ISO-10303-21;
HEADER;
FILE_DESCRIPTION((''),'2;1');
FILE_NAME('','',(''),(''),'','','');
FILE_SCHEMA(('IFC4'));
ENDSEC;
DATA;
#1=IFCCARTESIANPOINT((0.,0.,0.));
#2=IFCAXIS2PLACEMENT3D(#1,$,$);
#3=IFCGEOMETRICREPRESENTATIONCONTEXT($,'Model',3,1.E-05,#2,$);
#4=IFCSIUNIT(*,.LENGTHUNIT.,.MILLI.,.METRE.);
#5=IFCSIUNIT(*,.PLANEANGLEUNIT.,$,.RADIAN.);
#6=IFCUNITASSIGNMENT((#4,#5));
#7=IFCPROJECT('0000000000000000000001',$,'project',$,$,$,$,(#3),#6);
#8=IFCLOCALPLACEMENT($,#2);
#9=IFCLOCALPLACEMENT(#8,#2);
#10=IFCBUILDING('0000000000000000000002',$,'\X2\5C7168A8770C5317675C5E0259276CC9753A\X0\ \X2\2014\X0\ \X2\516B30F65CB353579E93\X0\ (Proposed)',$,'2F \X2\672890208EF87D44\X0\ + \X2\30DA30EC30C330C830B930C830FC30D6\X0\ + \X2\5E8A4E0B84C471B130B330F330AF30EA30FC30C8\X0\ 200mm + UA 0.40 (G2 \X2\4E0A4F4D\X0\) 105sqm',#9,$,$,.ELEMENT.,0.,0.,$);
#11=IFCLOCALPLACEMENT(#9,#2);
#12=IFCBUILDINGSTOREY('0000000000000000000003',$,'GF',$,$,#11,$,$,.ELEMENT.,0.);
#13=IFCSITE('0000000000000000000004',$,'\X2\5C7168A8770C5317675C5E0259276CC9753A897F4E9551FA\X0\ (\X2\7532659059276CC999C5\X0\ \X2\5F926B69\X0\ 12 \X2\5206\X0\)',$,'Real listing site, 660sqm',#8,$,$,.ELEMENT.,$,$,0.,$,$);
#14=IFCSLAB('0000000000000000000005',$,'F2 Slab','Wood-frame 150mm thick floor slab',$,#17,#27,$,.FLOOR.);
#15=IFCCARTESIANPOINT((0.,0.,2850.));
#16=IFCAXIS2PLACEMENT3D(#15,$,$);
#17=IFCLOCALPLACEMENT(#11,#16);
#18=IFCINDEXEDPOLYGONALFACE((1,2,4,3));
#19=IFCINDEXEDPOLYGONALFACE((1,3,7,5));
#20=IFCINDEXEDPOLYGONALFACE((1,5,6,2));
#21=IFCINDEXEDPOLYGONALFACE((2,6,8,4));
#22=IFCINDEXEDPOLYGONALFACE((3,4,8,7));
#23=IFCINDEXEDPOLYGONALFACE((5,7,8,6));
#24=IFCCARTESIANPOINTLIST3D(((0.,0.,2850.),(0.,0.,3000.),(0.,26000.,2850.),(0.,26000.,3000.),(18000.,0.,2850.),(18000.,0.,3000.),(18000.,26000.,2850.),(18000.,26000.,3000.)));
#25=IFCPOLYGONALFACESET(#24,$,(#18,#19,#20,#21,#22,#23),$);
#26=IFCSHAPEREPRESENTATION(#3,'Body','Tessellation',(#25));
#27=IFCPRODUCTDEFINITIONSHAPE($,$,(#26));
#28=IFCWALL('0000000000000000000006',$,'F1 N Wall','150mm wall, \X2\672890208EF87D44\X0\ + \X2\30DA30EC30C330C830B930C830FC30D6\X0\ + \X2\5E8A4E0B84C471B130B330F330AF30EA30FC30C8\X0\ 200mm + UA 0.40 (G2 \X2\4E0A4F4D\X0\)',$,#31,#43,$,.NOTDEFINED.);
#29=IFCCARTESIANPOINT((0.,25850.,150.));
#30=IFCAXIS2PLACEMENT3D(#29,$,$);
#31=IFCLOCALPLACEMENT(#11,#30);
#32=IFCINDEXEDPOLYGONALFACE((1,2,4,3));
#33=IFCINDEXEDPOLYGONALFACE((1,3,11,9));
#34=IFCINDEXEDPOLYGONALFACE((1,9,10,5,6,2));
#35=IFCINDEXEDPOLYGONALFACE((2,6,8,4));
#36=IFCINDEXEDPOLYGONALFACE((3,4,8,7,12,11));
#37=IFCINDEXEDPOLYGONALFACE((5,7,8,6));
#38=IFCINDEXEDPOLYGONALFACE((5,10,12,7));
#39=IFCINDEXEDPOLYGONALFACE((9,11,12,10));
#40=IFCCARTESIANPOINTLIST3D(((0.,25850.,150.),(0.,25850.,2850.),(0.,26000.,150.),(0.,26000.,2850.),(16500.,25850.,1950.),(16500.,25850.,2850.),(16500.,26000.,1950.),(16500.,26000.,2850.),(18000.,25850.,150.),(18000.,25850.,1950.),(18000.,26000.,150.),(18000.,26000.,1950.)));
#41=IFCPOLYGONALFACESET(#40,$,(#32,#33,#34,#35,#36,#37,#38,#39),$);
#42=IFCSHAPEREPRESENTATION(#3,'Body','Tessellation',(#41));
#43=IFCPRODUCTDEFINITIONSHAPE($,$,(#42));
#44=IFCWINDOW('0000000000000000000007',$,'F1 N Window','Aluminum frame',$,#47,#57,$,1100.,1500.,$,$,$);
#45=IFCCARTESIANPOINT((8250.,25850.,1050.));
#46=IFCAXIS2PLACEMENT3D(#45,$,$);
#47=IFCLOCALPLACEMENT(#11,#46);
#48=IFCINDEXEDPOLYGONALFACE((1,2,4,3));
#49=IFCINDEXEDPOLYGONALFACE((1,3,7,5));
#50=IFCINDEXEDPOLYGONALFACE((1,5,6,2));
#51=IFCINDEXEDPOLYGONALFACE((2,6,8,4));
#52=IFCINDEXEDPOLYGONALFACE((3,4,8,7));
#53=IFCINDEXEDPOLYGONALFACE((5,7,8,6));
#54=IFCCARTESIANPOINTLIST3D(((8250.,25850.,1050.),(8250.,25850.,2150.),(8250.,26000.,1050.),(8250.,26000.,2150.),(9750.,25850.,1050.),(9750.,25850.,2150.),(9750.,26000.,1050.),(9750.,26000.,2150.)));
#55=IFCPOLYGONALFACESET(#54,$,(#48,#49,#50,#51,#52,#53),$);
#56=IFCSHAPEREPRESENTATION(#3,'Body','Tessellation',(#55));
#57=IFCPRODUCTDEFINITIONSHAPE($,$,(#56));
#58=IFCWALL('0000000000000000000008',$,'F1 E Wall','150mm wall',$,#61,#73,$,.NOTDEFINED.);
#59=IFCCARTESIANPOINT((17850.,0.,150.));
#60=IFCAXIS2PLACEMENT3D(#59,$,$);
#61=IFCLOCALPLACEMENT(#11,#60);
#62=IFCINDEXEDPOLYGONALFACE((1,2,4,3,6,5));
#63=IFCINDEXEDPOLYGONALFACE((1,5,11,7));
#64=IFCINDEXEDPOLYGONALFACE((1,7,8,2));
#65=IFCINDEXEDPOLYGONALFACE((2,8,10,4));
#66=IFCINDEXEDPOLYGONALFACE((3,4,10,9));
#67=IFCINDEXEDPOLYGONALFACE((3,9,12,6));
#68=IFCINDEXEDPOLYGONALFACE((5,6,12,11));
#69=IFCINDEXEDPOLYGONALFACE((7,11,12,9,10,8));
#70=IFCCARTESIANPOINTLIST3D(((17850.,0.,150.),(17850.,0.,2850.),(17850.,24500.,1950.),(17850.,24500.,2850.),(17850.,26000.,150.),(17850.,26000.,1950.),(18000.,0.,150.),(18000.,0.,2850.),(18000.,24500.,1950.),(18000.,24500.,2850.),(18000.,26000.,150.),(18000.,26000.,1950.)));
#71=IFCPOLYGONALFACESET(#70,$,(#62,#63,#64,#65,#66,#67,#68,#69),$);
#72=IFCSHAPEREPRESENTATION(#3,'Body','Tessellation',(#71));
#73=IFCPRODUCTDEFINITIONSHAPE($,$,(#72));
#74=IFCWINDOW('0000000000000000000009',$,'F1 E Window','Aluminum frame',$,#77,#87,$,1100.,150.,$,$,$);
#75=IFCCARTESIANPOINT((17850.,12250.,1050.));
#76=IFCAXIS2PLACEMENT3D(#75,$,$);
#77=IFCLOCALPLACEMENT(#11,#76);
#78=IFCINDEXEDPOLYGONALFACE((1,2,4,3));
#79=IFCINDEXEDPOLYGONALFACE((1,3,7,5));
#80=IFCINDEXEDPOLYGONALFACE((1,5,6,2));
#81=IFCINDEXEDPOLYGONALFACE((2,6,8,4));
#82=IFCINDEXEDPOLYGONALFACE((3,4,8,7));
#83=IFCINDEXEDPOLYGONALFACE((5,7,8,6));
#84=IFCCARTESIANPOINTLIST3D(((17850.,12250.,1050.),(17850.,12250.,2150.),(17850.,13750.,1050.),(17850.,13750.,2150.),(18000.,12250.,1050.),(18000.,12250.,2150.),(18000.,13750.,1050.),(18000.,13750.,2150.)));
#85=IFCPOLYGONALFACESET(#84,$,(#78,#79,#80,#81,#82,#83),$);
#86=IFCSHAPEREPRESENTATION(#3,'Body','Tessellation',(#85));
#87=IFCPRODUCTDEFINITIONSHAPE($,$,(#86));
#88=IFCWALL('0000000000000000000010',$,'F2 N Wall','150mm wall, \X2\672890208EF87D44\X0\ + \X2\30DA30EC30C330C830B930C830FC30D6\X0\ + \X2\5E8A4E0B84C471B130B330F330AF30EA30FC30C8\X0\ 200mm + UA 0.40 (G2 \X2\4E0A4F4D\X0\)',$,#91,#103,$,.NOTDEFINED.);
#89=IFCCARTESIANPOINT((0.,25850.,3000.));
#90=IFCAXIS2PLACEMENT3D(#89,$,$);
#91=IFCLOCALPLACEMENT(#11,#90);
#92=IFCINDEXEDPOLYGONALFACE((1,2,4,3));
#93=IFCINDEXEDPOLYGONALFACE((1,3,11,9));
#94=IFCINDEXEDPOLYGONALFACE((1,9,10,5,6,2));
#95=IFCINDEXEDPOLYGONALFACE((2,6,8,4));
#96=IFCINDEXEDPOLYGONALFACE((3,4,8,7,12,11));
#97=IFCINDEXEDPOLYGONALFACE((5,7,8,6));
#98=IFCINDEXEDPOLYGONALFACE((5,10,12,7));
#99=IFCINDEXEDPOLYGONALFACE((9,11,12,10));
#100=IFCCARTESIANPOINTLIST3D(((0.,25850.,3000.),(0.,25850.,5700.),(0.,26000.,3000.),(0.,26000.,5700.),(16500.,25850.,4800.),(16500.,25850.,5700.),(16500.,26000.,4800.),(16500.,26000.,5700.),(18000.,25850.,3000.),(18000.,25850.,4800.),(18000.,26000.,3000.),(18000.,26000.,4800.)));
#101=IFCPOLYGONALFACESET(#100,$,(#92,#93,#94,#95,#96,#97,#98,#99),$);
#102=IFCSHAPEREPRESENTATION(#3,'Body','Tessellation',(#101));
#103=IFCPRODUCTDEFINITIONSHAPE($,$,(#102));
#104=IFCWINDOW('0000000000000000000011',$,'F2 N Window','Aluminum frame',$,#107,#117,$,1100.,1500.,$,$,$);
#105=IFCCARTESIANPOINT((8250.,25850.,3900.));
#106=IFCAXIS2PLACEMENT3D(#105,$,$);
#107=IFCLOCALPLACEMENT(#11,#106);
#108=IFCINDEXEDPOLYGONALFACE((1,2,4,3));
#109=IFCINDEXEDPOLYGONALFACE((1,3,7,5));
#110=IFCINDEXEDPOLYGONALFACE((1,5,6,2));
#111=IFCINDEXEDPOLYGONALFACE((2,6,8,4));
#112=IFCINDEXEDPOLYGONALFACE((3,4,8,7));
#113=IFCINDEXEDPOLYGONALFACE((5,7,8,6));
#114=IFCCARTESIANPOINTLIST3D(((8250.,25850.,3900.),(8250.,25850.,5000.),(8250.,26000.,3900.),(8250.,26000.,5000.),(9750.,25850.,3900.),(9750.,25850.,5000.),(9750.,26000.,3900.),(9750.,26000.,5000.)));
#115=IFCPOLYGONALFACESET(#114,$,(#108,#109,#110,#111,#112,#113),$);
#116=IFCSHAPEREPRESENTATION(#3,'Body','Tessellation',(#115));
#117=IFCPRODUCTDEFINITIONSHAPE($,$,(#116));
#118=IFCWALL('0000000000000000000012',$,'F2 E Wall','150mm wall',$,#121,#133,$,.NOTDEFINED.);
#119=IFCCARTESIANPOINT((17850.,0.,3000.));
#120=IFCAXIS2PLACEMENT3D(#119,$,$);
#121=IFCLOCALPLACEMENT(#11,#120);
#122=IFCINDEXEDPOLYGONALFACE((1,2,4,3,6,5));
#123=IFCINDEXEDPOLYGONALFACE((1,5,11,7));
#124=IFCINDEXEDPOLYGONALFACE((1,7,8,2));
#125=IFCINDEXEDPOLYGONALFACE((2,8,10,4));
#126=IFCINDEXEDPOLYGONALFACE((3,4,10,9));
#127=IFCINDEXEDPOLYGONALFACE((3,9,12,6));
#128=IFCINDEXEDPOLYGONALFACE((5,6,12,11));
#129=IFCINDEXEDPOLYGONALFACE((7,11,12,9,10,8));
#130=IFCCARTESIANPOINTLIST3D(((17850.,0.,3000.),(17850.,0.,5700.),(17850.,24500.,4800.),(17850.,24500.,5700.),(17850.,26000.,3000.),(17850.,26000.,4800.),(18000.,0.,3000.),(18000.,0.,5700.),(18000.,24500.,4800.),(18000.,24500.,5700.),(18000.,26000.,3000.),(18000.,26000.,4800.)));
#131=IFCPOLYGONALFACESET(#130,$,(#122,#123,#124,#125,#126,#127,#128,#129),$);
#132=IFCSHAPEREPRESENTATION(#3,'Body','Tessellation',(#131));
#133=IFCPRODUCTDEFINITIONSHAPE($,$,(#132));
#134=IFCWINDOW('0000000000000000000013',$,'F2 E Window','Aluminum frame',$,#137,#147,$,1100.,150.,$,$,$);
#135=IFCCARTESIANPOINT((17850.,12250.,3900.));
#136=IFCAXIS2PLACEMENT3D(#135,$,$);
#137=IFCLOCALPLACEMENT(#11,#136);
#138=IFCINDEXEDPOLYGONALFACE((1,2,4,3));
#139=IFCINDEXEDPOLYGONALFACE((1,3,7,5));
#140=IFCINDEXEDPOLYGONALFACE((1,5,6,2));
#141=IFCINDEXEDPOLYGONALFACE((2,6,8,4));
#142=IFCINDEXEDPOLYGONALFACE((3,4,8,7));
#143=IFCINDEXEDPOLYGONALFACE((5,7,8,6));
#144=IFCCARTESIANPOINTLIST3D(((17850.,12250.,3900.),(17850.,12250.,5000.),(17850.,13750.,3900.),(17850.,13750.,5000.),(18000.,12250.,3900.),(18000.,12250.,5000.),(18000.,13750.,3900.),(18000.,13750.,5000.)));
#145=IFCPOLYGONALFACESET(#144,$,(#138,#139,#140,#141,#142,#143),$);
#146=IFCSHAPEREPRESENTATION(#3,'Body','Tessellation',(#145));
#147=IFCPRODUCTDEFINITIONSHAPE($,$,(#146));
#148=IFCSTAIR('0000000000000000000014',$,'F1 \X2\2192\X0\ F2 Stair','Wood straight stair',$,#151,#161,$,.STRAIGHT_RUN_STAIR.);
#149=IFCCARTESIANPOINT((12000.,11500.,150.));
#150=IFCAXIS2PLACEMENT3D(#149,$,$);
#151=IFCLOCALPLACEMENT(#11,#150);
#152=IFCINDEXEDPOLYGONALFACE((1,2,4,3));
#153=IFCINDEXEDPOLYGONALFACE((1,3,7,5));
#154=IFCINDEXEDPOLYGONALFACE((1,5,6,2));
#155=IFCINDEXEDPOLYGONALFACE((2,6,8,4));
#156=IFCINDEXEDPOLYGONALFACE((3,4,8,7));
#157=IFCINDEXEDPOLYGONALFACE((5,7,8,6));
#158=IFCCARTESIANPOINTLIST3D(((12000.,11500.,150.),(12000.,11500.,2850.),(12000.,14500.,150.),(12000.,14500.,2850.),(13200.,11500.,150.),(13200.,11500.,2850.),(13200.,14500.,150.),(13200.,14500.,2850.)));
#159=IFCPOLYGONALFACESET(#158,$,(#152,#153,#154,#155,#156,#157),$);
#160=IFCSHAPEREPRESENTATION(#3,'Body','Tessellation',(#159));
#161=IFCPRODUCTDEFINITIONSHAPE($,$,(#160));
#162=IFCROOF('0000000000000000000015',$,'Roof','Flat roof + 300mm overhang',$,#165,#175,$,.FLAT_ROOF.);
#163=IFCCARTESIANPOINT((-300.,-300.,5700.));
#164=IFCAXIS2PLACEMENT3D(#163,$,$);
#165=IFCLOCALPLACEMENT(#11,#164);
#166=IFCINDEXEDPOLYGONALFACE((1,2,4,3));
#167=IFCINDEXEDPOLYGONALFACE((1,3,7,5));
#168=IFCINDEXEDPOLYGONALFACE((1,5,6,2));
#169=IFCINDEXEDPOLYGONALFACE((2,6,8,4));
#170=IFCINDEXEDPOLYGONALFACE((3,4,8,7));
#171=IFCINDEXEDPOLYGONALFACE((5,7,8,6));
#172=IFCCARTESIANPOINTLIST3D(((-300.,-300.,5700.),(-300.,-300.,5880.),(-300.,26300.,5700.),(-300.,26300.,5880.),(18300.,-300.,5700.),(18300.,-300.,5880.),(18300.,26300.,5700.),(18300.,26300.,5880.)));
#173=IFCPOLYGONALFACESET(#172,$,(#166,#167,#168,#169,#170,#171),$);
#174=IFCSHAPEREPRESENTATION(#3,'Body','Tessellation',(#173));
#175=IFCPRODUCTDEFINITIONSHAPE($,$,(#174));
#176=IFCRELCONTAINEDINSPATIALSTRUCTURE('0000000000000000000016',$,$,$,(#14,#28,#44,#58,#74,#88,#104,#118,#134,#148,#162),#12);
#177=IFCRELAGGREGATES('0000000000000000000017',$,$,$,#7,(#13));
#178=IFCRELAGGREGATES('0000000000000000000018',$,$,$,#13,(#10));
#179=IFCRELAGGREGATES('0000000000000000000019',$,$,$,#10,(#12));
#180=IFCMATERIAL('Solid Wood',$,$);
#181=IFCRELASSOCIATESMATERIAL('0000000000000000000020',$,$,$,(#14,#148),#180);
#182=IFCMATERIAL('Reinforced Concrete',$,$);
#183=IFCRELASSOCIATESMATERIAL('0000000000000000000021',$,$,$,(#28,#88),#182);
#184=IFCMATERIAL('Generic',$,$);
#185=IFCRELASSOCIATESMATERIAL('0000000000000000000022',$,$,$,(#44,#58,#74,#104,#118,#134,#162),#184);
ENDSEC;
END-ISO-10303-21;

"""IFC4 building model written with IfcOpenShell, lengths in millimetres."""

from ifc_helpers import new_model, si_unit, frame, frame_2d, origin, place, context, project, spatial, rectangle, extrude, material, element, fill, save


model = new_model("IFC4")

# Units and contexts
model_context = context("Model", 3, precision=1e-05, world=origin())
ifc_project = project(units=[si_unit("LENGTHUNIT", "METRE", prefix="MILLI"), si_unit("PLANEANGLEUNIT", "RADIAN")], contexts=[model_context])

# Site, building, storey
site_placement = place(None, origin())
site = spatial("IfcSite", under=ifc_project, at=site_placement, Name="山梨県北杜市大泉町西井出 (甲斐大泉駅 徒歩 12 分)", ObjectType="Real listing site, 660sqm", CompositionType="ELEMENT", RefElevation=0.0)
building_placement = place(site_placement, origin())
building = spatial("IfcBuilding", under=site, at=building_placement, Name="山梨県北杜市大泉町 — 八ヶ岳南麓 (Proposed)", ObjectType="2F 木造軸組 + ペレットストーブ + 床下蓄熱コンクリート 200mm + UA 0.40 (G2 上位) 105sqm", CompositionType="ELEMENT", ElevationOfRefHeight=0.0, ElevationOfTerrain=0.0)
storey_placement = place(building_placement, origin())
storey = spatial("IfcBuildingStorey", under=building, at=storey_placement, Name="GF", CompositionType="ELEMENT", Elevation=0.0)

# Slab
ifc_material_1 = material(Name="Solid Wood")
slab_1_placement = place(storey_placement, frame((0.0, 0.0, 2850.0)))
element("IfcSlab", 1, at=slab_1_placement, inside=storey, material=ifc_material_1, Name="F2 Slab", Description="Wood-frame 150mm thick floor slab", PredefinedType="FLOOR", context=model_context, shape_type="SweptSolid", body=[
    extrude(rectangle(XDim=18000.0, YDim=26000.0, at=frame_2d((9000.0, 13000.0))), frame((0.0, 0.0, 2850.0)), (0.0, 0.0, 1.0), 150.0),
])

# Wall, opening, window
ifc_material_2 = material(Name="Reinforced Concrete")
wall_1_placement = place(storey_placement, frame((0.0, 25850.0, 150.0)))
wall_1 = element("IfcWall", 2, at=wall_1_placement, inside=storey, material=ifc_material_2, Name="F1 N Wall", Description="150mm wall, 木造軸組 + ペレットストーブ + 床下蓄熱コンクリート 200mm + UA 0.40 (G2 上位)", PredefinedType="NOTDEFINED", context=model_context, shape_type="SweptSolid", body=[
    extrude(rectangle(XDim=18000.0, YDim=150.0, at=frame_2d((9000.0, 75.0))), frame((0.0, 25850.0, 150.0)), (0.0, 0.0, 1.0), 2700.0),
])
opening_1_placement = place(storey_placement, frame((8250.0, 25850.0, 1050.0)))
opening_1 = element("IfcOpeningElement", 3, at=opening_1_placement, cuts=wall_1, PredefinedType="NOTDEFINED", context=model_context, shape_type="SweptSolid", body=[
    extrude(rectangle(XDim=1500.0, YDim=150.0, at=frame_2d((750.0, 75.0))), frame((8250.0, 25850.0, 1050.0)), (0.0, 0.0, 1.0), 1100.0),
])
ifc_material_3 = material(Name="Generic")
window_1_placement = place(storey_placement, frame((8250.0, 25850.0, 1050.0)))
window_1 = element("IfcWindow", 4, at=window_1_placement, inside=storey, material=ifc_material_3, Name="F1 N Window", Description="Aluminum frame", OverallHeight=1100.0, OverallWidth=1500.0, context=model_context, shape_type="SweptSolid", body=[
    extrude(rectangle(XDim=1500.0, YDim=150.0, at=frame_2d((750.0, 75.0))), frame((8250.0, 25850.0, 1050.0)), (0.0, 0.0, 1.0), 1100.0),
])
fill(opening_1, window_1)

# Walls, openings, windows
wall_2_placement = place(storey_placement, frame((17850.0, 0.0, 150.0)))
wall_2 = element("IfcWall", 5, at=wall_2_placement, inside=storey, material=ifc_material_3, Name="F1 E Wall", Description="150mm wall", PredefinedType="NOTDEFINED", context=model_context, shape_type="SweptSolid", body=[
    extrude(rectangle(XDim=150.0, YDim=26000.0, at=frame_2d((75.0, 13000.0))), frame((17850.0, 0.0, 150.0)), (0.0, 0.0, 1.0), 2700.0),
])
opening_2_placement = place(storey_placement, frame((17850.0, 12250.0, 1050.0)))
opening_2 = element("IfcOpeningElement", 6, at=opening_2_placement, cuts=wall_2, PredefinedType="NOTDEFINED", context=model_context, shape_type="SweptSolid", body=[
    extrude(rectangle(XDim=150.0, YDim=1500.0, at=frame_2d((75.0, 750.0))), frame((17850.0, 12250.0, 1050.0)), (0.0, 0.0, 1.0), 1100.0),
])
window_2_placement = place(storey_placement, frame((17850.0, 12250.0, 1050.0)))
window_2 = element("IfcWindow", 7, at=window_2_placement, inside=storey, material=ifc_material_3, Name="F1 E Window", Description="Aluminum frame", OverallHeight=1100.0, OverallWidth=150.0, context=model_context, shape_type="SweptSolid", body=[
    extrude(rectangle(XDim=150.0, YDim=1500.0, at=frame_2d((75.0, 750.0))), frame((17850.0, 12250.0, 1050.0)), (0.0, 0.0, 1.0), 1100.0),
])
fill(opening_2, window_2)
wall_3_placement = place(storey_placement, frame((0.0, 25850.0, 3000.0)))
wall_3 = element("IfcWall", 8, at=wall_3_placement, inside=storey, material=ifc_material_2, Name="F2 N Wall", Description="150mm wall, 木造軸組 + ペレットストーブ + 床下蓄熱コンクリート 200mm + UA 0.40 (G2 上位)", PredefinedType="NOTDEFINED", context=model_context, shape_type="SweptSolid", body=[
    extrude(rectangle(XDim=18000.0, YDim=150.0, at=frame_2d((9000.0, 75.0))), frame((0.0, 25850.0, 3000.0)), (0.0, 0.0, 1.0), 2700.0),
])
opening_3_placement = place(storey_placement, frame((8250.0, 25850.0, 3900.0)))
opening_3 = element("IfcOpeningElement", 9, at=opening_3_placement, cuts=wall_3, PredefinedType="NOTDEFINED", context=model_context, shape_type="SweptSolid", body=[
    extrude(rectangle(XDim=1500.0, YDim=150.0, at=frame_2d((750.0, 75.0))), frame((8250.0, 25850.0, 3900.0)), (0.0, 0.0, 1.0), 1100.0),
])
window_3_placement = place(storey_placement, frame((8250.0, 25850.0, 3900.0)))
window_3 = element("IfcWindow", 10, at=window_3_placement, inside=storey, material=ifc_material_3, Name="F2 N Window", Description="Aluminum frame", OverallHeight=1100.0, OverallWidth=1500.0, context=model_context, shape_type="SweptSolid", body=[
    extrude(rectangle(XDim=1500.0, YDim=150.0, at=frame_2d((750.0, 75.0))), frame((8250.0, 25850.0, 3900.0)), (0.0, 0.0, 1.0), 1100.0),
])
fill(opening_3, window_3)
wall_4_placement = place(storey_placement, frame((17850.0, 0.0, 3000.0)))
wall_4 = element("IfcWall", 11, at=wall_4_placement, inside=storey, material=ifc_material_3, Name="F2 E Wall", Description="150mm wall", PredefinedType="NOTDEFINED", context=model_context, shape_type="SweptSolid", body=[
    extrude(rectangle(XDim=150.0, YDim=26000.0, at=frame_2d((75.0, 13000.0))), frame((17850.0, 0.0, 3000.0)), (0.0, 0.0, 1.0), 2700.0),
])
opening_4_placement = place(storey_placement, frame((17850.0, 12250.0, 3900.0)))
opening_4 = element("IfcOpeningElement", 12, at=opening_4_placement, cuts=wall_4, PredefinedType="NOTDEFINED", context=model_context, shape_type="SweptSolid", body=[
    extrude(rectangle(XDim=150.0, YDim=1500.0, at=frame_2d((75.0, 750.0))), frame((17850.0, 12250.0, 3900.0)), (0.0, 0.0, 1.0), 1100.0),
])
window_4_placement = place(storey_placement, frame((17850.0, 12250.0, 3900.0)))
window_4 = element("IfcWindow", 13, at=window_4_placement, inside=storey, material=ifc_material_3, Name="F2 E Window", Description="Aluminum frame", OverallHeight=1100.0, OverallWidth=150.0, context=model_context, shape_type="SweptSolid", body=[
    extrude(rectangle(XDim=150.0, YDim=1500.0, at=frame_2d((75.0, 750.0))), frame((17850.0, 12250.0, 3900.0)), (0.0, 0.0, 1.0), 1100.0),
])
fill(opening_4, window_4)

# Stair
stair_placement = place(storey_placement, frame((12000.0, 11500.0, 150.0)))
element("IfcStair", 14, at=stair_placement, inside=storey, material=ifc_material_1, Name="F1 → F2 Stair", Description="Wood straight stair", PredefinedType="STRAIGHT_RUN_STAIR", context=model_context, shape_type="SweptSolid", body=[
    extrude(rectangle(XDim=1200.0, YDim=3000.0, at=frame_2d((600.0, 1500.0))), frame((12000.0, 11500.0, 150.0)), (0.0, 0.0, 1.0), 2700.0),
])

# Roof
roof_placement = place(storey_placement, frame((-300.0, -300.0, 5700.0)))
element("IfcRoof", 15, at=roof_placement, inside=storey, material=ifc_material_3, Name="Roof", Description="Flat roof + 300mm overhang", PredefinedType="FLAT_ROOF", context=model_context, shape_type="SweptSolid", body=[
    extrude(rectangle(XDim=18600.0, YDim=26600.0, at=frame_2d((9300.0, 13300.0))), frame((-300.0, -300.0, 5700.0)), (0.0, 0.0, 1.0), 180.0),
])

save(model, "model.ifc")
